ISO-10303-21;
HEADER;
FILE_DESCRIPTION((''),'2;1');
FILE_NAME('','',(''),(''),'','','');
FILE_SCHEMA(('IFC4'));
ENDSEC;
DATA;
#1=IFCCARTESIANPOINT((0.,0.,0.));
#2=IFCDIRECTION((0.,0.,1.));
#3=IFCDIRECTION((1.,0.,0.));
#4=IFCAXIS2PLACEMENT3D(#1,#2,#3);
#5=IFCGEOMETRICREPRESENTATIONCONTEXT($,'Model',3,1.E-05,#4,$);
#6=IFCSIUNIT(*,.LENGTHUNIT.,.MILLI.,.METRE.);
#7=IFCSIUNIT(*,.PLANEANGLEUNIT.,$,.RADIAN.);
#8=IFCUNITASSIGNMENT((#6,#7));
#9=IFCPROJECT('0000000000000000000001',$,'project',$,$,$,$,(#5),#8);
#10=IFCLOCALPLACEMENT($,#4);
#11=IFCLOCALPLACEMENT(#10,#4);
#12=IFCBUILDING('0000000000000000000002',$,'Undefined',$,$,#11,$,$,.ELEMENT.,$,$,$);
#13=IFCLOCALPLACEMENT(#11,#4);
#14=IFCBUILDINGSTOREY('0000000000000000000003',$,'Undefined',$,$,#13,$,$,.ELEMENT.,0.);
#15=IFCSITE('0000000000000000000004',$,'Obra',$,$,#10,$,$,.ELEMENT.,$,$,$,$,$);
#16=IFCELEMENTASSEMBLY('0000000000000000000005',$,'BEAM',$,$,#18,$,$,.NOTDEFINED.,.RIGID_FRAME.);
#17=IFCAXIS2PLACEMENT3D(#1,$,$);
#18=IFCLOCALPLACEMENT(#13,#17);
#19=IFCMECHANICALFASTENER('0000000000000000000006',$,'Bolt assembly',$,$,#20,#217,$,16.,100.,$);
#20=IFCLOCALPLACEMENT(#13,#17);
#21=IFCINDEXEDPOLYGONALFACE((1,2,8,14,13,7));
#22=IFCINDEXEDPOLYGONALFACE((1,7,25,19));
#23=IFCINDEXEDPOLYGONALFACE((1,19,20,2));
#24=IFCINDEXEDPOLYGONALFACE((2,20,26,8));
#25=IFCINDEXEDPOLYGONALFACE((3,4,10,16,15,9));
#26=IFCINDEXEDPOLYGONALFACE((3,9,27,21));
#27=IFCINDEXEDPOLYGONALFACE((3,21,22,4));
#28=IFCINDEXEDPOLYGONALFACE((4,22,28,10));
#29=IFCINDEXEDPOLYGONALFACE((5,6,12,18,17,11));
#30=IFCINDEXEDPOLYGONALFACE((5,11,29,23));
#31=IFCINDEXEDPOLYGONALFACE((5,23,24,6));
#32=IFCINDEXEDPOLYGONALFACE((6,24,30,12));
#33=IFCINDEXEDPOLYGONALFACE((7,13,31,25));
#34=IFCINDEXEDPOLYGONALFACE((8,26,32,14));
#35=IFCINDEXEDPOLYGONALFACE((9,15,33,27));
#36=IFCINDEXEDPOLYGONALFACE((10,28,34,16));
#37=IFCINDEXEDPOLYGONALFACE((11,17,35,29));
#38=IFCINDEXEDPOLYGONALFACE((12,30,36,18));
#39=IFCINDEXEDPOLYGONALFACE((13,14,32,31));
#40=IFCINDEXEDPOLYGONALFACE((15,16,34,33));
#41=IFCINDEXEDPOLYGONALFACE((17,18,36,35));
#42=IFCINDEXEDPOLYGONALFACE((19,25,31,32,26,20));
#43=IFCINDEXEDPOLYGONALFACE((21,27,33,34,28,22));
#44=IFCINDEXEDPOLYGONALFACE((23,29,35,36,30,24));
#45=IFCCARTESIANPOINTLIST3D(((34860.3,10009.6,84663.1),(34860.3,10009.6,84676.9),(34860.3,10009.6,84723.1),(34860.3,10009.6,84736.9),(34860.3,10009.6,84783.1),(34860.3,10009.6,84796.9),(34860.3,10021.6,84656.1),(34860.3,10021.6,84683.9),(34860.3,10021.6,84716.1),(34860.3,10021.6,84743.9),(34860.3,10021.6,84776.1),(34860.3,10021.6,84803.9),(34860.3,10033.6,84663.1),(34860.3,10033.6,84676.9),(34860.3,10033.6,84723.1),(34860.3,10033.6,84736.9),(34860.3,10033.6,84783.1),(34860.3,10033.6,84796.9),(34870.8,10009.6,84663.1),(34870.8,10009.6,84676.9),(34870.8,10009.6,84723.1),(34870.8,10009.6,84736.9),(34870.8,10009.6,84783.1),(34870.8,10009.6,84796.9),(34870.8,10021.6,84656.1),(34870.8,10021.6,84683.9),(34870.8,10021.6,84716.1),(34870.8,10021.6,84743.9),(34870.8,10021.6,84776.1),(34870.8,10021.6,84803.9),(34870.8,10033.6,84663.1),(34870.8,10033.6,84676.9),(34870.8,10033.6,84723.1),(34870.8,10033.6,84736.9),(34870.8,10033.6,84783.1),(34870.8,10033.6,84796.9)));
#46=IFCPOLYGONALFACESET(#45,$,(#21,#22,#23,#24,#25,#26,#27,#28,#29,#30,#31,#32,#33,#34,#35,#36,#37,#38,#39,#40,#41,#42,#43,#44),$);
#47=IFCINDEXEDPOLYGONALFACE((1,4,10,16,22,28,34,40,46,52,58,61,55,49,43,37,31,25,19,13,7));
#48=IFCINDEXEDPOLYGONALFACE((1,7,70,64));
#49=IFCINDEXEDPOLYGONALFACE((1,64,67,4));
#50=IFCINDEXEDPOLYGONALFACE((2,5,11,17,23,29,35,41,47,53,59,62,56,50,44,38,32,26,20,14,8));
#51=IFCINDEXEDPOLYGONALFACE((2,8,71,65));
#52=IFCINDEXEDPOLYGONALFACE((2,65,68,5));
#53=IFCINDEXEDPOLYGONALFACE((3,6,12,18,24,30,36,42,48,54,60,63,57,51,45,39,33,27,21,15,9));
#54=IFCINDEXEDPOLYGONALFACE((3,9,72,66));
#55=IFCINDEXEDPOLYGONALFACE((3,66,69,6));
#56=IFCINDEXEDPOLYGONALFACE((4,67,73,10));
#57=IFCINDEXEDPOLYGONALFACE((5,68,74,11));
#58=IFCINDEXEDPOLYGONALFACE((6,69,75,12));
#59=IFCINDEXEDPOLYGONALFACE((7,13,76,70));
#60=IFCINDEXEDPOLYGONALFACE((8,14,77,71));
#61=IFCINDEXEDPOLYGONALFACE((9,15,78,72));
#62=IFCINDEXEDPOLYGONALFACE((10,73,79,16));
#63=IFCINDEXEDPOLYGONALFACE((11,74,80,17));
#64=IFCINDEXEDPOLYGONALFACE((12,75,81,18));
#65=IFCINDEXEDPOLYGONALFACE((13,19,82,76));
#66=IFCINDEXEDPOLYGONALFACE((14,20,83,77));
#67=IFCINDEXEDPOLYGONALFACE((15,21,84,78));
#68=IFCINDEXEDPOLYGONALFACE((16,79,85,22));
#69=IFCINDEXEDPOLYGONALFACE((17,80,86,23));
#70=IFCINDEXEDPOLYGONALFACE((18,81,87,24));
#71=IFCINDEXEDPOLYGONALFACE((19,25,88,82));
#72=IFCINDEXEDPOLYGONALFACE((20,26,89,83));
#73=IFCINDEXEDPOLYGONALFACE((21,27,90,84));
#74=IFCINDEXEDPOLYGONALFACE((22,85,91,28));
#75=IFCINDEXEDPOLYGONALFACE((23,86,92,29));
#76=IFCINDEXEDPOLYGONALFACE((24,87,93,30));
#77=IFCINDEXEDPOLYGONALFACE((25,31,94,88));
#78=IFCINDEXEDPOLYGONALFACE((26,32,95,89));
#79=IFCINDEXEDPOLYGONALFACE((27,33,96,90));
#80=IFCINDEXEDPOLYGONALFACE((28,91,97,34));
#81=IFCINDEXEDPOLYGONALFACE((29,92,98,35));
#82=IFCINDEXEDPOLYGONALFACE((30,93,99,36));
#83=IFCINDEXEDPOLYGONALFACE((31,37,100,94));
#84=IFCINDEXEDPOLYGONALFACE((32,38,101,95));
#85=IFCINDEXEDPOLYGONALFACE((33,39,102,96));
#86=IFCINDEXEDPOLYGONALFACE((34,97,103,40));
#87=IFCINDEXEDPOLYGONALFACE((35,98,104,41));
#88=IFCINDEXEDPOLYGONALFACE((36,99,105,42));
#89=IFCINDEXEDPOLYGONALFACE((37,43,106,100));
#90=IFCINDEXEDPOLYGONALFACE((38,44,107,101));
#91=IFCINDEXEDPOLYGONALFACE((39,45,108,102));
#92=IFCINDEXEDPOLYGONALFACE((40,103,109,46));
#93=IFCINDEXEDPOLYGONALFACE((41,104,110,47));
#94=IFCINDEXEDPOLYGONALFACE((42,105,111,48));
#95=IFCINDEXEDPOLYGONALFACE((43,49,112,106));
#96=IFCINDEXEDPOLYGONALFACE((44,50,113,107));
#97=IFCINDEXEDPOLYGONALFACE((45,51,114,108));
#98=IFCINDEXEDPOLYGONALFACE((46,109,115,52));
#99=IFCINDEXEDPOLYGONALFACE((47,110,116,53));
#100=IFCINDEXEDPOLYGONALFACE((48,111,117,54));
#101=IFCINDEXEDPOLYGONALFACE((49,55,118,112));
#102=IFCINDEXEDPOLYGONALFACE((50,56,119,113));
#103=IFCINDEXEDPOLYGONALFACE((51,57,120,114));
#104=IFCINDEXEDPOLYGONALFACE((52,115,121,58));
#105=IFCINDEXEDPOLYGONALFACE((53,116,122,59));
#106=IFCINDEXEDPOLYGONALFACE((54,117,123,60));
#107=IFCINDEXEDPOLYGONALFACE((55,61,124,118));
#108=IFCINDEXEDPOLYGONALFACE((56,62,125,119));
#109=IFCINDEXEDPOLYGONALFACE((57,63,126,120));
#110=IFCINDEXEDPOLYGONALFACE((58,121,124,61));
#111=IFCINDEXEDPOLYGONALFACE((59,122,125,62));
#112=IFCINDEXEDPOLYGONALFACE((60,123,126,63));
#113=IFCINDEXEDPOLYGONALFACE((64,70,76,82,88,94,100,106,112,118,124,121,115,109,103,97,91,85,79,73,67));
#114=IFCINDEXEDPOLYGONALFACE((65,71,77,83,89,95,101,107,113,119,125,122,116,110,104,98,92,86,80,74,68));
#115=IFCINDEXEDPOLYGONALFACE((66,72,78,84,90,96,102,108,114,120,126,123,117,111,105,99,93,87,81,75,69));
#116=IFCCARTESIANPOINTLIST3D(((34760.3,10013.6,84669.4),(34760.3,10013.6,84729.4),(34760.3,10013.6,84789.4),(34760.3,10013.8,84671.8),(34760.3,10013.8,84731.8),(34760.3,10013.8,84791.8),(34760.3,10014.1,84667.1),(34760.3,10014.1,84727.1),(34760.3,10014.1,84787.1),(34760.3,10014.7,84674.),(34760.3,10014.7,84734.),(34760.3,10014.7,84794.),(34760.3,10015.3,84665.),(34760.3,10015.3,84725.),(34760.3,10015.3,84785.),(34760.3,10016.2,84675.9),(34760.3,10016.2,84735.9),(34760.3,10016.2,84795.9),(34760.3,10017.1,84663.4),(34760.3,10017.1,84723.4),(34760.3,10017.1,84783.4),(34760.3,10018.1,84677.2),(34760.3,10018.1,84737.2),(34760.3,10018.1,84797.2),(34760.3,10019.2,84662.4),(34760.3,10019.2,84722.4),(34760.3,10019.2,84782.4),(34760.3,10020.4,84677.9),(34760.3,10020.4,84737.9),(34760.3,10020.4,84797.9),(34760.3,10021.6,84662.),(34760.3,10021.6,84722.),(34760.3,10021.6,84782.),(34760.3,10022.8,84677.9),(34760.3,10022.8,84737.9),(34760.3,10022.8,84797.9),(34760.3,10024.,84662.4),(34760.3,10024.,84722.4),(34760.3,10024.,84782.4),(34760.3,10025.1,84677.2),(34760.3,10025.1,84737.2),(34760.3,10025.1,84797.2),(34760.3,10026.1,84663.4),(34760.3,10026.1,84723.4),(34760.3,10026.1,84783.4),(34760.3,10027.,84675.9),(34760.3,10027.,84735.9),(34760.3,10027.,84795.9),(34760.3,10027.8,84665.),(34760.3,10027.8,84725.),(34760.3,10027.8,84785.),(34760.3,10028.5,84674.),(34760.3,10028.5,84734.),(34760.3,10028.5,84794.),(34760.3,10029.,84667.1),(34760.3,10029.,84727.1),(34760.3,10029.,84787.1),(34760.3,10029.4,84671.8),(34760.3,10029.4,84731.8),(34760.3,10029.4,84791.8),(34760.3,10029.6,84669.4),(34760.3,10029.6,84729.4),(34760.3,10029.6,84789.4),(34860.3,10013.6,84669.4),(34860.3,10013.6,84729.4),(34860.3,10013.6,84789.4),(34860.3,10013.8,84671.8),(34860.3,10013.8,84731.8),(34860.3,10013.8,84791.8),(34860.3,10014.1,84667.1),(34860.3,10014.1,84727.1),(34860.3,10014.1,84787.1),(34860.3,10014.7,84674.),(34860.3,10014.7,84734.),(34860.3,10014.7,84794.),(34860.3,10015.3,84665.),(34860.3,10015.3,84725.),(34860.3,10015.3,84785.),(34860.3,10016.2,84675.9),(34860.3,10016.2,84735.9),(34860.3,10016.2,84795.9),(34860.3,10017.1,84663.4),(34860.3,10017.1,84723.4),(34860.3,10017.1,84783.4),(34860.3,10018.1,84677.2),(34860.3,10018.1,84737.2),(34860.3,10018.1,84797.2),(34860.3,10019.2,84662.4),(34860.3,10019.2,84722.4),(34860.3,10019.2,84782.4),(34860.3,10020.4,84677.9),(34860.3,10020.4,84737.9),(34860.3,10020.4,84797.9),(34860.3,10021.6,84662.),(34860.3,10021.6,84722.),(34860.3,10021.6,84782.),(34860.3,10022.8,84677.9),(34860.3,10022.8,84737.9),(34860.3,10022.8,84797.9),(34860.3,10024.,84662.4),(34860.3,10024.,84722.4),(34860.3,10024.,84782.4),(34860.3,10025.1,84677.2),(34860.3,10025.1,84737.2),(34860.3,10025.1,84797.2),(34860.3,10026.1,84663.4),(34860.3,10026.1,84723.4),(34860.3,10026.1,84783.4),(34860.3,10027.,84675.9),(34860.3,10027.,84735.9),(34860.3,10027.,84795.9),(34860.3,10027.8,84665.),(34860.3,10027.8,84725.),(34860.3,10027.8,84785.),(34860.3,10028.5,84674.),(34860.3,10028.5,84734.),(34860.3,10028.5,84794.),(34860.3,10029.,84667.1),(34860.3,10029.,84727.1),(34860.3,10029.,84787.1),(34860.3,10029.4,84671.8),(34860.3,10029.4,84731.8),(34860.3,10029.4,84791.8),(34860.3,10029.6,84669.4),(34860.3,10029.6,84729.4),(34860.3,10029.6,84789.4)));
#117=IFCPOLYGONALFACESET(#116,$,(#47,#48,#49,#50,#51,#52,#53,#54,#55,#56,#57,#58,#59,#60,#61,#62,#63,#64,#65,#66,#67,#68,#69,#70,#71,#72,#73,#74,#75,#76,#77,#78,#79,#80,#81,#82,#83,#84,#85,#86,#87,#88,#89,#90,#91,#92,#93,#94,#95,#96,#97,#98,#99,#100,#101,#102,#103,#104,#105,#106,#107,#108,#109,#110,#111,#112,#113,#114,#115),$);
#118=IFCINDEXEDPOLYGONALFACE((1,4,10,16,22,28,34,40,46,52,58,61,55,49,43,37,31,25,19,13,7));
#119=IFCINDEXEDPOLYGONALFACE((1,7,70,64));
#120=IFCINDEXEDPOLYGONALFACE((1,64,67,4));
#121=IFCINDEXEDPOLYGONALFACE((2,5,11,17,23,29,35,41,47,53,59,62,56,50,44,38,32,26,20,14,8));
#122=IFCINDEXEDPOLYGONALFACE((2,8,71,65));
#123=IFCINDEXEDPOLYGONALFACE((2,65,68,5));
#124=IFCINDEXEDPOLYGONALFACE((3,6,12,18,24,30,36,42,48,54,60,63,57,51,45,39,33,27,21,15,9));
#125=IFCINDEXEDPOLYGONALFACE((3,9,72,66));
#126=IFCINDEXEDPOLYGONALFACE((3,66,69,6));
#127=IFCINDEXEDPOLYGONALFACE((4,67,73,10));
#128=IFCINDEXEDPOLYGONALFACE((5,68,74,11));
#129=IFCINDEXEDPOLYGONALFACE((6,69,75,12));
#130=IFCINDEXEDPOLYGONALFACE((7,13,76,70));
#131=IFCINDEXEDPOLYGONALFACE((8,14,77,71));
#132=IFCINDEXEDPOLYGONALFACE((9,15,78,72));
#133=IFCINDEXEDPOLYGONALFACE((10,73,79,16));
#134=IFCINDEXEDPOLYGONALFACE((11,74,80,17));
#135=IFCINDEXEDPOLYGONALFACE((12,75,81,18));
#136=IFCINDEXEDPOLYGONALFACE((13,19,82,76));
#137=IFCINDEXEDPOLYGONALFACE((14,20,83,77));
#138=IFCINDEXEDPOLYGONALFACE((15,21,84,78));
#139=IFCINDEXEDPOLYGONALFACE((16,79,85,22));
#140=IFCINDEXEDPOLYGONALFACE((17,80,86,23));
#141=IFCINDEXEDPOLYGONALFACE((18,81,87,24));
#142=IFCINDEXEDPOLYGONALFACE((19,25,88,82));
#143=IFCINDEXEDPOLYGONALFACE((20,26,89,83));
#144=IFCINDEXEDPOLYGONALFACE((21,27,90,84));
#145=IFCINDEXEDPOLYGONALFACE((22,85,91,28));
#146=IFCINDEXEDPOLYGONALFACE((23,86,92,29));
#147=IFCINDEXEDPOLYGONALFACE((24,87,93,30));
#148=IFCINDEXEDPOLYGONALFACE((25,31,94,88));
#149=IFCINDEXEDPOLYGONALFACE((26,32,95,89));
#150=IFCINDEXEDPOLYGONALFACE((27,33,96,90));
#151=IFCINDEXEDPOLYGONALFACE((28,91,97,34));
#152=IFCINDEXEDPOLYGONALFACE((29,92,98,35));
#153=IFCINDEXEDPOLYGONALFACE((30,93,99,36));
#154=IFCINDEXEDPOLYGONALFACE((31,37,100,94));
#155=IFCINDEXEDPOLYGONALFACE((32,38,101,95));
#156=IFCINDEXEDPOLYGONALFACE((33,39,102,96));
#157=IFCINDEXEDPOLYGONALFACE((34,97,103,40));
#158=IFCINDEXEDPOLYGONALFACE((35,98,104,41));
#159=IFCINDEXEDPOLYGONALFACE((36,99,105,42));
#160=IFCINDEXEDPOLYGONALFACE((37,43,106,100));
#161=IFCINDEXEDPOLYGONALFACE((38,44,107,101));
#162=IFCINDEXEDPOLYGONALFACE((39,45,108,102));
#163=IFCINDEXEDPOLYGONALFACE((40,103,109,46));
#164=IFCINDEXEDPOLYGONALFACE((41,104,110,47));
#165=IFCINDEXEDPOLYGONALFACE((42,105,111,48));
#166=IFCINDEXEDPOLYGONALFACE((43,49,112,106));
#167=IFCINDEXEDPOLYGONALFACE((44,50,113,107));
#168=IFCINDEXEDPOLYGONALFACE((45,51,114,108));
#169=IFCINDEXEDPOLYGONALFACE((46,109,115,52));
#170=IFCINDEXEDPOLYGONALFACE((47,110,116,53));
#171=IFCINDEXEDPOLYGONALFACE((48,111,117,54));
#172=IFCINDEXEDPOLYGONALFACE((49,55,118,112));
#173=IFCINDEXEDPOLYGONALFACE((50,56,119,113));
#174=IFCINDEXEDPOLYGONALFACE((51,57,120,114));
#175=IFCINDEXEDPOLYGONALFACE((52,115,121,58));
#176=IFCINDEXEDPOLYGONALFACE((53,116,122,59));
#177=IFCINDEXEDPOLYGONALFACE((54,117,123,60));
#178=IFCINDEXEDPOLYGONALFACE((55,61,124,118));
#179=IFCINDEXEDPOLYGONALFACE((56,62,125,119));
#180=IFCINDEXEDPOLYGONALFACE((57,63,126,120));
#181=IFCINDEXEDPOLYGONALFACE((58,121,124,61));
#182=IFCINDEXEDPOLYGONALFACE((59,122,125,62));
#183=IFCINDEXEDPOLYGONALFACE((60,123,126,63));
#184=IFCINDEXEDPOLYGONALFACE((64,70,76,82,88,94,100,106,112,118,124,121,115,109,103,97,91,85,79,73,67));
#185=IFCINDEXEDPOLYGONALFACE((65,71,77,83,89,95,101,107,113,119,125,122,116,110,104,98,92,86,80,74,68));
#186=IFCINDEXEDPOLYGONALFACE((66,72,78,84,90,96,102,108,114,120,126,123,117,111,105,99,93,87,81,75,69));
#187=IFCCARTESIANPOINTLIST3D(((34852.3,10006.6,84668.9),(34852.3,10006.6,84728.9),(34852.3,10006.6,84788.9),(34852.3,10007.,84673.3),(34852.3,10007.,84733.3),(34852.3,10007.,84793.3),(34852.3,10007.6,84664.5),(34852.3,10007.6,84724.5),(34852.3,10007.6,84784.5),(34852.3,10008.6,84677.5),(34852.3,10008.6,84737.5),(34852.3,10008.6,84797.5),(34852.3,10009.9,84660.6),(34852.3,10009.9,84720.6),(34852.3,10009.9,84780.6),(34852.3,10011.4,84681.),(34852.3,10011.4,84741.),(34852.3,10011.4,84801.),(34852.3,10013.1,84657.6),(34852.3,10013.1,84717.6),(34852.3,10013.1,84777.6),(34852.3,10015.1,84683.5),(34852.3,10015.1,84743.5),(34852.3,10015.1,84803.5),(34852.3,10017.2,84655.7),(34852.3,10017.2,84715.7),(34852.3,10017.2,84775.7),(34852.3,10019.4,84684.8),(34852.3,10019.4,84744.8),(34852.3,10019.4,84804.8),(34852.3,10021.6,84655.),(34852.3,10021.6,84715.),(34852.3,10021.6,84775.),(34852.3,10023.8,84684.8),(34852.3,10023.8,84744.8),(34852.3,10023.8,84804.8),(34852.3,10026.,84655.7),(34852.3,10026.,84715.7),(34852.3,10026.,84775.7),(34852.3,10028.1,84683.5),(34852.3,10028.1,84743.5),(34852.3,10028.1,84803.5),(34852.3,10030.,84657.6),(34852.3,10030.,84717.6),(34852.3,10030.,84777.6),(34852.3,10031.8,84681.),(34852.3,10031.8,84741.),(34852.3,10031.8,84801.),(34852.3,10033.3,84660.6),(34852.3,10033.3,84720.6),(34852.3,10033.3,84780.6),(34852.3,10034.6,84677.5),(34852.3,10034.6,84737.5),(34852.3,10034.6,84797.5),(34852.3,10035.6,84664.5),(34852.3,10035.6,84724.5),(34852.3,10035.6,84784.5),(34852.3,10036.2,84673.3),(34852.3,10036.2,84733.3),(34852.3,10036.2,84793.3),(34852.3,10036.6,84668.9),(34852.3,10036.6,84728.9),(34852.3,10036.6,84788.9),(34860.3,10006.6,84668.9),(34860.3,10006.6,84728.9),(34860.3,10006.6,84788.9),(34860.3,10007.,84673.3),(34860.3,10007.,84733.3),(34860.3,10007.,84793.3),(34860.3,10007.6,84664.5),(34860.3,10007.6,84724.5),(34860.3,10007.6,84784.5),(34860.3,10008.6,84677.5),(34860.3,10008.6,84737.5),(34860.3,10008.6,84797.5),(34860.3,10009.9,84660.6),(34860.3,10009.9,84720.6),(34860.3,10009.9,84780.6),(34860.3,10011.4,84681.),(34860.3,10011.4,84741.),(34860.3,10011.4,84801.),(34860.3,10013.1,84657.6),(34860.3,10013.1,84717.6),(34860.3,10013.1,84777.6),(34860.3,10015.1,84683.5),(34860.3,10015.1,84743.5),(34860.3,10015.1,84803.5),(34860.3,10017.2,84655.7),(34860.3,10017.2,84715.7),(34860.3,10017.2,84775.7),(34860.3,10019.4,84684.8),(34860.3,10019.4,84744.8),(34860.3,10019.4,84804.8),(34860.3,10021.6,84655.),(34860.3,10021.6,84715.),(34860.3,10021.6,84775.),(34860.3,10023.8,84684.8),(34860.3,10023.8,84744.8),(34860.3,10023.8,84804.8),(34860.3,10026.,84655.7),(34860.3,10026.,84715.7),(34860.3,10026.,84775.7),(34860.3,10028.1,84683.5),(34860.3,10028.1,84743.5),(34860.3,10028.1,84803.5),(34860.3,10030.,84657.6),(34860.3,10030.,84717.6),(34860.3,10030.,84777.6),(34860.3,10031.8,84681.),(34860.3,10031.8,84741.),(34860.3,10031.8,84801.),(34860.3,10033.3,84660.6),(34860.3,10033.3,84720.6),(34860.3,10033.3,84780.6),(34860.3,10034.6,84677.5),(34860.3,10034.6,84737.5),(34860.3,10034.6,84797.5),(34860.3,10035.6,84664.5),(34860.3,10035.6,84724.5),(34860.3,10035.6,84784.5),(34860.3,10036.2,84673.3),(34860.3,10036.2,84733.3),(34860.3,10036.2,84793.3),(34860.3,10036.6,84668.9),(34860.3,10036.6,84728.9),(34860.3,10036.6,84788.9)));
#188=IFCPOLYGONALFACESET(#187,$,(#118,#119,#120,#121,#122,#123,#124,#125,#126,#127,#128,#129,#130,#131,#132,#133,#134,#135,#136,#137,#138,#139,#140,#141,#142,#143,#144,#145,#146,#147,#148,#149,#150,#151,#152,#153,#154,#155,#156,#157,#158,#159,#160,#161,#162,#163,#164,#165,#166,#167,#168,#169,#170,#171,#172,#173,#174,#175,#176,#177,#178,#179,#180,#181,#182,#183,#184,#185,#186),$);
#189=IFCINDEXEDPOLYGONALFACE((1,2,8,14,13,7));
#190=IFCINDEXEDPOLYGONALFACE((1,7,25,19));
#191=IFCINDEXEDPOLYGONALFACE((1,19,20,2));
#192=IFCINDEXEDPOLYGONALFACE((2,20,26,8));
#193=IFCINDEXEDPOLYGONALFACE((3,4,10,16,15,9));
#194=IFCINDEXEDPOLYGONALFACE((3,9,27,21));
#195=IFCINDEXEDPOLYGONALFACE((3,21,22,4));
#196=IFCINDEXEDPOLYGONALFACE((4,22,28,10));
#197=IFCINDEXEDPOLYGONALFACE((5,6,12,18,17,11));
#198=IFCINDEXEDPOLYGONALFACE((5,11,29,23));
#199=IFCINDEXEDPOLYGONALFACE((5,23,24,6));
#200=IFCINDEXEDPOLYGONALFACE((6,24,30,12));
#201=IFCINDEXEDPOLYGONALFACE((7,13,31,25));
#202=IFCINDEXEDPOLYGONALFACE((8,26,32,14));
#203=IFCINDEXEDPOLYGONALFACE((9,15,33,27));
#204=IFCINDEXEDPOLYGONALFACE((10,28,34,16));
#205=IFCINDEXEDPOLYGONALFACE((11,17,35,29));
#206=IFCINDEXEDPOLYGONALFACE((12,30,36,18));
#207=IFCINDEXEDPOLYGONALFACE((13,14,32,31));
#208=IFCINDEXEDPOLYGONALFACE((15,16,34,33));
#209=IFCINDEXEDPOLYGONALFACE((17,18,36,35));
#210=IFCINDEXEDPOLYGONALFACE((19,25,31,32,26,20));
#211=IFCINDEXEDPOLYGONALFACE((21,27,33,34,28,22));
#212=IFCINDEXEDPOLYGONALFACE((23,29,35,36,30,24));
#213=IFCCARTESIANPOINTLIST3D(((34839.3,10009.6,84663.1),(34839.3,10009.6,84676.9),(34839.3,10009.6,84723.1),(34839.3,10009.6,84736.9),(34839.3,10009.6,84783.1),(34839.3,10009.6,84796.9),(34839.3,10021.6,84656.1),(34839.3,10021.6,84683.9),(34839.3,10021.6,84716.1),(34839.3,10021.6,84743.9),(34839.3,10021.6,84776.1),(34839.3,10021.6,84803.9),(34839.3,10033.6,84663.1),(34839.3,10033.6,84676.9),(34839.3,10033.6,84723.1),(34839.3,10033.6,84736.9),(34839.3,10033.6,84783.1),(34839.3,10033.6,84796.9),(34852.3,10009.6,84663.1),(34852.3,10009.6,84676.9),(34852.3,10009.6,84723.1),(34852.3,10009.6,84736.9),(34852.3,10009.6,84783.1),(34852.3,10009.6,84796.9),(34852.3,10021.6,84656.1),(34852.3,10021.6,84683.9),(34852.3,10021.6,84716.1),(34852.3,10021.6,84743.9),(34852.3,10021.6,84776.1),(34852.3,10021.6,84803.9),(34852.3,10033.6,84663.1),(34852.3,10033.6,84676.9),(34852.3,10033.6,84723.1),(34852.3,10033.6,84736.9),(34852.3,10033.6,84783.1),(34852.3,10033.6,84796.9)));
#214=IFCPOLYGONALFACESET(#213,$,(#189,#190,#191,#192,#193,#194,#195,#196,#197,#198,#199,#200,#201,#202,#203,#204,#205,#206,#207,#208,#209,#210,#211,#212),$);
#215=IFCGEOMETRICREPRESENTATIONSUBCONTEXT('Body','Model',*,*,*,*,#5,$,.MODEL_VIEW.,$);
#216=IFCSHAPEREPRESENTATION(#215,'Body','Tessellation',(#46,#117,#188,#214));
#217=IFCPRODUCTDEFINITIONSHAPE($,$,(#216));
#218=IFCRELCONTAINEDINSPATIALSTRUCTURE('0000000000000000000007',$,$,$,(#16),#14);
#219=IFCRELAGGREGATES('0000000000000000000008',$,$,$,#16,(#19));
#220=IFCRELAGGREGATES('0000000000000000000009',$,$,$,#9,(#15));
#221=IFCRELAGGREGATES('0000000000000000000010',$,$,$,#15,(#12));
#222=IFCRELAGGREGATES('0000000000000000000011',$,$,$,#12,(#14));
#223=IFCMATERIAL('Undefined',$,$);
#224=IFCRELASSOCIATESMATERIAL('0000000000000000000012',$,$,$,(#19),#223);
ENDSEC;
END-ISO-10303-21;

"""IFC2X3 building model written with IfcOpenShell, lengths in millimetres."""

from ifc_helpers import new_model, si_unit, frame, origin_with_axes, origin_2d_with_axis, place, context, subcontext, project, spatial, polyline, circle, outline, extrude, source, transform, mapped, material, element, aggregate, save


model = new_model("IFC2X3")

# Units and contexts
model_context = context("Model", 3, precision=1e-05, world=origin_with_axes())
body_context = subcontext(model_context, "Body", "Model", "MODEL_VIEW")
ifc_project = project(units=[si_unit("LENGTHUNIT", "METRE", prefix="MILLI"), si_unit("PLANEANGLEUNIT", "RADIAN")], contexts=[model_context])

# Site, building, storey
site_placement = place(None, origin_with_axes())
site = spatial("IfcSite", under=ifc_project, at=site_placement, Name="Obra", CompositionType="ELEMENT")
building_placement = place(site_placement, origin_with_axes())
building = spatial("IfcBuilding", under=site, at=building_placement, Name="Undefined", CompositionType="ELEMENT")
storey_placement = place(building_placement, origin_with_axes())
storey = spatial("IfcBuildingStorey", under=building, at=storey_placement, Name="Undefined", CompositionType="ELEMENT", Elevation=0.0)

# Shared definitions
ifc_material_1 = material(Name="Undefined")

# Element assembly, mechanical fastener
assembly_1_placement = place(storey_placement, origin_with_axes())
assembly_1 = element("IfcElementAssembly", 1, at=assembly_1_placement, inside=storey, Name="BEAM", AssemblyPlace="NOTDEFINED", PredefinedType="RIGID_FRAME")
shared_shape_1 = source(origin_with_axes(), body_context, "Body", "SweptSolid", [
    extrude(outline(polyline([(13.9, 0.0), (6.9, 12.0), (-6.9, 12.0), (-13.9, 0.0), (-6.9, -12.0), (6.9, -12.0), (13.9, 0.0)])), frame((0.0, -10.6, 0.0), z_axis=(0.0, 1.0, 0.0), x_axis=(1.0, 0.0, 0.0)), (0.0, 0.0, 1.0), 10.6),
    extrude(circle(Radius=8.0, at=origin_2d_with_axis()), frame((0.0, 0.0, 0.0), z_axis=(0.0, 1.0, 0.0), x_axis=(1.0, 0.0, 0.0)), (0.0, 0.0, 1.0), 100.0),
    extrude(circle(Radius=15.0, at=origin_2d_with_axis()), frame((0.0, 0.0, 0.0), z_axis=(0.0, 1.0, 0.0), x_axis=(1.0, 0.0, 0.0)), (0.0, 0.0, 1.0), 8.0),
    extrude(outline(polyline([(13.9, 0.0), (6.9, 12.0), (-6.9, 12.0), (-13.9, 0.0), (-6.9, -12.0), (6.9, -12.0), (13.9, 0.0)])), frame((0.0, 8.0, 0.0), z_axis=(0.0, 1.0, 0.0), x_axis=(1.0, 0.0, 0.0)), (0.0, 0.0, 1.0), 13.0),
])
mechanical_fastener_1_placement = place(assembly_1_placement, frame((34860.3, 9971.6, 84850.0), z_axis=(0.0, 1.0, 0.0), x_axis=(0.0, 0.0, -1.0)))
mechanical_fastener_1 = element("IfcMechanicalFastener", 2, at=mechanical_fastener_1_placement, material=ifc_material_1, Name="Bolt assembly", NominalDiameter=16.0, NominalLength=100.0, context=body_context, shape_type="MappedRepresentation", body=[
    mapped(shared_shape_1, transform((60.0, 0.0, 50.0))),
    mapped(shared_shape_1, transform((120.0, 0.0, 50.0))),
    mapped(shared_shape_1, transform((180.0, 0.0, 50.0))),
])
aggregate(assembly_1, [mechanical_fastener_1])

save(model, "model.ifc")
